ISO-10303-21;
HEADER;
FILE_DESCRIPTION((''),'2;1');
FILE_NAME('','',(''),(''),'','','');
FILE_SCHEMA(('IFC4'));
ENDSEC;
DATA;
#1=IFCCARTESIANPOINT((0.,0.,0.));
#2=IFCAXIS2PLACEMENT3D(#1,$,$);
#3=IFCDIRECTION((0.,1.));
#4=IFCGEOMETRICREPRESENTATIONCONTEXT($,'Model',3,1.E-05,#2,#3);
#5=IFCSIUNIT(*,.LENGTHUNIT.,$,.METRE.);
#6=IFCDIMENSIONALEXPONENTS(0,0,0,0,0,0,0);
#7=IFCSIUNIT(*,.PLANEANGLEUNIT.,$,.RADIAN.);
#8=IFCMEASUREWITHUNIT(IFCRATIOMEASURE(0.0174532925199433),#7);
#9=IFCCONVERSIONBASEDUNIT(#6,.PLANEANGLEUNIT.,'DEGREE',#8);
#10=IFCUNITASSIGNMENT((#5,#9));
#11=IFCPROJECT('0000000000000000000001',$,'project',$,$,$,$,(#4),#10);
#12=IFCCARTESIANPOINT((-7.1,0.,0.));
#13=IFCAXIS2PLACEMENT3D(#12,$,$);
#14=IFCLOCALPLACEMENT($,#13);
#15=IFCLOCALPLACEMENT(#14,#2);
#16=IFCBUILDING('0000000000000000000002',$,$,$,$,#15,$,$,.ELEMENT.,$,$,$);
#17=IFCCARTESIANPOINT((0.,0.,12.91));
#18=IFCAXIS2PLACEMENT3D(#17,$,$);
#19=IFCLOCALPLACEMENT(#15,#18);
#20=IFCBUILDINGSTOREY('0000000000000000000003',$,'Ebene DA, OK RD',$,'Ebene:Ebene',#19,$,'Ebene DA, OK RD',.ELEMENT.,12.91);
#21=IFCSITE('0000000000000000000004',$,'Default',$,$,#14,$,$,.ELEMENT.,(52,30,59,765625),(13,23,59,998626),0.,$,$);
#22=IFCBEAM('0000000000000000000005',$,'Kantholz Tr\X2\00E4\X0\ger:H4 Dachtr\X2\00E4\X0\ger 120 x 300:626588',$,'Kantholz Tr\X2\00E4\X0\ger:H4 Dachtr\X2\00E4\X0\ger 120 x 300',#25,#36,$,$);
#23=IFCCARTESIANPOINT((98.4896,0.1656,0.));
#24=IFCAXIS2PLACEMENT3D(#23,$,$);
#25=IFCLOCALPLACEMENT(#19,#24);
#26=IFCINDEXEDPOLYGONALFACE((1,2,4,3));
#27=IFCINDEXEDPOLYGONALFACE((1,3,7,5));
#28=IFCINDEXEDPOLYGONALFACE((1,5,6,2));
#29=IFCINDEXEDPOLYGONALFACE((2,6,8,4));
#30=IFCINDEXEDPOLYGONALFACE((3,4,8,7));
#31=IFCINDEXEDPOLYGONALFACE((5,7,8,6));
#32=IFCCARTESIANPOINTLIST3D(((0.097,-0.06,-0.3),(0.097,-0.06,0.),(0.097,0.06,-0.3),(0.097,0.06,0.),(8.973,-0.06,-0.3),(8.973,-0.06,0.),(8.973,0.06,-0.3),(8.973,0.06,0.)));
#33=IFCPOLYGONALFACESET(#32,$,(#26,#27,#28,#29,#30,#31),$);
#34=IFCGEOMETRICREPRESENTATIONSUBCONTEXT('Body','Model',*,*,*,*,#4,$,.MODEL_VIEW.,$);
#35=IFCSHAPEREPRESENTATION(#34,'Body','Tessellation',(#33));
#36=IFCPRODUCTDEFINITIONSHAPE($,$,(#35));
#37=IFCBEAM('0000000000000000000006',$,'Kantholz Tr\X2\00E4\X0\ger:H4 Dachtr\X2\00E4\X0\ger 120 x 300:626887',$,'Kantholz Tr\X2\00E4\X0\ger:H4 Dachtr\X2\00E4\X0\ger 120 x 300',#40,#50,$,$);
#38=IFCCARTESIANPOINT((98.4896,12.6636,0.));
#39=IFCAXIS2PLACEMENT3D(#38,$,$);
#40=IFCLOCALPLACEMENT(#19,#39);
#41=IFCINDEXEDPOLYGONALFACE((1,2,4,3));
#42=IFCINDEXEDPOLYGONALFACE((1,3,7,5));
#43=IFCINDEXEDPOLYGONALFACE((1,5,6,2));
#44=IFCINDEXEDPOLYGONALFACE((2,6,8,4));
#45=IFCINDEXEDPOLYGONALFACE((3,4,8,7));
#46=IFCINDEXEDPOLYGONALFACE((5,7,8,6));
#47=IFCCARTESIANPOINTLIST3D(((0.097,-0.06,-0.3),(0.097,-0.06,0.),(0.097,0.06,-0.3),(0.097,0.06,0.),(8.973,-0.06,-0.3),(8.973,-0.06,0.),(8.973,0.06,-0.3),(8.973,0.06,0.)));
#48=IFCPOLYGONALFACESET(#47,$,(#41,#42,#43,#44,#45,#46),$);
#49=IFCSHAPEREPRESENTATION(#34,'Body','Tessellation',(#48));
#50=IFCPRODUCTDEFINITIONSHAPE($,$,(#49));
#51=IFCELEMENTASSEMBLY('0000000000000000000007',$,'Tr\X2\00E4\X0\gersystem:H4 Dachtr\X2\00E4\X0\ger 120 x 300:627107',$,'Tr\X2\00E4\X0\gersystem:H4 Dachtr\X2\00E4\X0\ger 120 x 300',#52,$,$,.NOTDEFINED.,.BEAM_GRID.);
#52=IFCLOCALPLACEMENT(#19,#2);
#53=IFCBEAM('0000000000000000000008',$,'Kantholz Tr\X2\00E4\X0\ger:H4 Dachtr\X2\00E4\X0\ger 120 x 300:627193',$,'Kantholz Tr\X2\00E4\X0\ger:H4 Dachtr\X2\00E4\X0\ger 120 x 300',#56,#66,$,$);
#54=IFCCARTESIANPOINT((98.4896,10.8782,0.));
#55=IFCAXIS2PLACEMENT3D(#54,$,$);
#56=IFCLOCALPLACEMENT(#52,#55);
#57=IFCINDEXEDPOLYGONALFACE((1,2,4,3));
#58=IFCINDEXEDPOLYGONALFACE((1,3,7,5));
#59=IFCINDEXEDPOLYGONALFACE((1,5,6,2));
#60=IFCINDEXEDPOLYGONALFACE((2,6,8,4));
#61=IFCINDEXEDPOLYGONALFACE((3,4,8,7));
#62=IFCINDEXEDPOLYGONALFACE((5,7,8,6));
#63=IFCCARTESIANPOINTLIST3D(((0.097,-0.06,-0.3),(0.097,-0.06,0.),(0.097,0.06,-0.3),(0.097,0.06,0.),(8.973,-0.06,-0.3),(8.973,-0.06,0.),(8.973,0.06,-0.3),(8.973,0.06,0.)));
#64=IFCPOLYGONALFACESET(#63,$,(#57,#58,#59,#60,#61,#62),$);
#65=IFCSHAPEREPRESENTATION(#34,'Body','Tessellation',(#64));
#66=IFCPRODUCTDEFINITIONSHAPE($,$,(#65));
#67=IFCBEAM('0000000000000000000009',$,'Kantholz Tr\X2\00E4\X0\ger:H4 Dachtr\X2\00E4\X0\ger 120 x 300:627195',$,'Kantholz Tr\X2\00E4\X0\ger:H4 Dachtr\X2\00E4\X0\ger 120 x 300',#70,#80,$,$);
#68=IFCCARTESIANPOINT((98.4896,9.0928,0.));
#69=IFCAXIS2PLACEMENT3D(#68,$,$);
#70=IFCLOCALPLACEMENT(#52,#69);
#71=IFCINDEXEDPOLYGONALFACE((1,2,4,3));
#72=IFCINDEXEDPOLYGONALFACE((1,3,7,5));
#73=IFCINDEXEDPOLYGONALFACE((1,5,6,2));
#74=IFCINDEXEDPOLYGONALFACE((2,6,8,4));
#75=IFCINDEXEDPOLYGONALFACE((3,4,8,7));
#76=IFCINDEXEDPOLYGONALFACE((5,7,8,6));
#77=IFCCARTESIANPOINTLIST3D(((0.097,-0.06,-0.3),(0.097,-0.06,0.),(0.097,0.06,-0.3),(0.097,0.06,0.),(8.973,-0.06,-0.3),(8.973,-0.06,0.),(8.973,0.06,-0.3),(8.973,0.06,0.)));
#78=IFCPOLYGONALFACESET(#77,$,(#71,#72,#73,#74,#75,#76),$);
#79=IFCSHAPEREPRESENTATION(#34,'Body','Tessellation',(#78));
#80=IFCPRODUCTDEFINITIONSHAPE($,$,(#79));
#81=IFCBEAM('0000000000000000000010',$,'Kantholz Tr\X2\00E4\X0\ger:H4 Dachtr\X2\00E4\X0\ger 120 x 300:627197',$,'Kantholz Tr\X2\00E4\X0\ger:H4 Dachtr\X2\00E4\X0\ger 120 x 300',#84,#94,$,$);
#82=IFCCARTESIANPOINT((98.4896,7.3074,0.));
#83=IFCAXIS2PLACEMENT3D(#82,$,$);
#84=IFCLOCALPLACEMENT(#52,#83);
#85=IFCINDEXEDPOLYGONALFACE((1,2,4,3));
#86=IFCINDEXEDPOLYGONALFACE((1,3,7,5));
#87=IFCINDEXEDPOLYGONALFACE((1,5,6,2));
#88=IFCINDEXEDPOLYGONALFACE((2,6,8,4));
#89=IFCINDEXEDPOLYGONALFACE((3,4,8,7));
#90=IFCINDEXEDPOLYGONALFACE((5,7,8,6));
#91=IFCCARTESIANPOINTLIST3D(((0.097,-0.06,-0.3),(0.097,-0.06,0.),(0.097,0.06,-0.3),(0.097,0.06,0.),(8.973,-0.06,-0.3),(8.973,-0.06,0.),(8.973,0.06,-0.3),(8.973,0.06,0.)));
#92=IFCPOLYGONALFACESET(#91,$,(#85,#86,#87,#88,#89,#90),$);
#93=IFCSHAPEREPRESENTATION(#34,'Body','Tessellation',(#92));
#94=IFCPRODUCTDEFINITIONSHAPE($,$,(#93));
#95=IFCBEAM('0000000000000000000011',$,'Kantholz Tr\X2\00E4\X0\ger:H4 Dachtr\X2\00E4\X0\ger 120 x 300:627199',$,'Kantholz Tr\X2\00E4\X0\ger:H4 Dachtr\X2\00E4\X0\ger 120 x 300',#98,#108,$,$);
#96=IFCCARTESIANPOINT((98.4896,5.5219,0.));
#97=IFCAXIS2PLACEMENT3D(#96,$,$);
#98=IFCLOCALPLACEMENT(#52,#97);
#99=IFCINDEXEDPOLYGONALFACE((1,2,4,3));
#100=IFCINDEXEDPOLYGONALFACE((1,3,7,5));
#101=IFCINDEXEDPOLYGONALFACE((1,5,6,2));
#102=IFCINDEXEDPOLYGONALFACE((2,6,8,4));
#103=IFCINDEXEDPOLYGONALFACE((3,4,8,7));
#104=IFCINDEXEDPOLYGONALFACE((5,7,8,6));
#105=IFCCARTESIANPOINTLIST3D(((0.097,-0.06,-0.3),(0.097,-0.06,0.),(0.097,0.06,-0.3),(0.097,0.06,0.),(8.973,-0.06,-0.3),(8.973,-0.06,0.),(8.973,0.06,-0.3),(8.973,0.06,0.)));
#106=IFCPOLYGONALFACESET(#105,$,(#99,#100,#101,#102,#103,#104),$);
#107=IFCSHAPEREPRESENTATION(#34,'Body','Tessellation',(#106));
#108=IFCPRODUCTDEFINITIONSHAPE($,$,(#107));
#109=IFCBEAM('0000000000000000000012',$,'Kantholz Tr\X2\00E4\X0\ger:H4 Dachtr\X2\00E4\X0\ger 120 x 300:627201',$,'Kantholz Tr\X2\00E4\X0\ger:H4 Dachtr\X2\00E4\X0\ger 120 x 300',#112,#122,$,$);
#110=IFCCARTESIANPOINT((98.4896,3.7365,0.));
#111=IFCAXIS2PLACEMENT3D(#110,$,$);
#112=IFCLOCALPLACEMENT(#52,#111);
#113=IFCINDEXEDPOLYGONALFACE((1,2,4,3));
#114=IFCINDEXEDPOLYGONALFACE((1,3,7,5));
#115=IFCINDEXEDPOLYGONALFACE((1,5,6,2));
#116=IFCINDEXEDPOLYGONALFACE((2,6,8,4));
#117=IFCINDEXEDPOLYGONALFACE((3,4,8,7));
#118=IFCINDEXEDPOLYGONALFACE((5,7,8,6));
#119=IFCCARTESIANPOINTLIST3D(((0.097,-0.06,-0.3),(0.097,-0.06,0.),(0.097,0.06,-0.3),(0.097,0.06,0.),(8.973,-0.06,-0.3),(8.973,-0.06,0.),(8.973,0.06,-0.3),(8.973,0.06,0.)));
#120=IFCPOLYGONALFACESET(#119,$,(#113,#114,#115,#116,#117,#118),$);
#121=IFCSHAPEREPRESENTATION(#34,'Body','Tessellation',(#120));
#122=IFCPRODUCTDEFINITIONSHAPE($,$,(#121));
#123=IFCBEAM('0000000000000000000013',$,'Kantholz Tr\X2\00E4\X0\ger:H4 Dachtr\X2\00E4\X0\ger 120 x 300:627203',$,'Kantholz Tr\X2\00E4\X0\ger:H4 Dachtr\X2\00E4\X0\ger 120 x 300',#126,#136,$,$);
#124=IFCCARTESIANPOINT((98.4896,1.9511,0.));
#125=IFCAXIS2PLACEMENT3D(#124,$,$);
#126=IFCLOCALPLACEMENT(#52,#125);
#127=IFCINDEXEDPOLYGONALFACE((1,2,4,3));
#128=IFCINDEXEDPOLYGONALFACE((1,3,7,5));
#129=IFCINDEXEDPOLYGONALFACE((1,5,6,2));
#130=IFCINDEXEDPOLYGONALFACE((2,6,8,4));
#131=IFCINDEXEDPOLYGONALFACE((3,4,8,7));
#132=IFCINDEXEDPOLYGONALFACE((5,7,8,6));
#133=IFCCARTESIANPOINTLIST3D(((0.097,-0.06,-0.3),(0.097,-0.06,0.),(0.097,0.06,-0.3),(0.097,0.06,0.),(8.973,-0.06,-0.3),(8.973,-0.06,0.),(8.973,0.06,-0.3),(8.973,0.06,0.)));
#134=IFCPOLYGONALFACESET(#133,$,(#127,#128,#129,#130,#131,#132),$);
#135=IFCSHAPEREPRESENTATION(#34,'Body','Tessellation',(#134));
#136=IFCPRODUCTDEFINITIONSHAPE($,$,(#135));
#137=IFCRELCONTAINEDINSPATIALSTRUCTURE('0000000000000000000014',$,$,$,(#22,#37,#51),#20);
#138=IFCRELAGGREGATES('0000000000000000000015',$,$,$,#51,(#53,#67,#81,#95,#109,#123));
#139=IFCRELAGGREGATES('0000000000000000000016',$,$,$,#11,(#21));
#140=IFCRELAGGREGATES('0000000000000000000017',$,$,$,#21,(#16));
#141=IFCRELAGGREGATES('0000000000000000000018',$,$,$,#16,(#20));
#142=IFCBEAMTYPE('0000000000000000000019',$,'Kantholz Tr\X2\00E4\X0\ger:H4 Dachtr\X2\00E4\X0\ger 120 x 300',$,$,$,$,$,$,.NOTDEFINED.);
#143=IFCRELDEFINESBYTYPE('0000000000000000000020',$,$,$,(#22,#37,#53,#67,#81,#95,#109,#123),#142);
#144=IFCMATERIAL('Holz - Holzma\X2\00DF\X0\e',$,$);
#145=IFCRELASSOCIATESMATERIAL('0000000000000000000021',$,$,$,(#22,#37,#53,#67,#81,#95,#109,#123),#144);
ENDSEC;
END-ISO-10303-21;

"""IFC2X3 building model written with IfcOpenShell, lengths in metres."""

from ifc_helpers import new_model, entity, si_unit, converted_unit, direction, frame, frame_2d, origin, place, context, subcontext, project, spatial, rectangle, extrude, material, type_object, element, aggregate, save


model = new_model("IFC2X3")

# Units and contexts
model_context = context("Model", 3, precision=1e-05, world=origin(), true_north=direction((0.0, 1.0)))
body_context = subcontext(model_context, "Body", "Model", "MODEL_VIEW")
ifc_project = project(units=[si_unit("LENGTHUNIT", "METRE"), converted_unit("PLANEANGLEUNIT", "DEGREE", entity("IfcRatioMeasure", 0.0174532925199433), si_unit("PLANEANGLEUNIT", "RADIAN"), dimensions=[0, 0, 0, 0, 0, 0, 0])], contexts=[model_context])

# Site, building, storey
site_placement = place(None, frame((-7.1, 0.0, 0.0)))
site = spatial("IfcSite", under=ifc_project, at=site_placement, Name="Default", CompositionType="ELEMENT", RefLatitude=(52, 30, 59, 765625), RefLongitude=(13, 23, 59, 998626), RefElevation=0.0)
building_placement = place(site_placement, origin())
building = spatial("IfcBuilding", under=site, at=building_placement, CompositionType="ELEMENT")
storey_placement = place(building_placement, frame((0.0, 0.0, 12.91)))
storey = spatial("IfcBuildingStorey", under=building, at=storey_placement, Name="Ebene DA, OK RD", ObjectType="Ebene:Ebene", LongName="Ebene DA, OK RD", CompositionType="ELEMENT", Elevation=12.91)

# Beams
ifc_material_1 = material(Name="Holz - Holzmaße")
beam_type = type_object("IfcBeamType", Name="Kantholz Träger:H4 Dachträger 120 x 300", PredefinedType="NOTDEFINED")
beam_1_placement = place(storey_placement, frame((98.4896, 0.1656, 0.0)))
element("IfcBeam", 1, at=beam_1_placement, inside=storey, type_object=beam_type, material=ifc_material_1, Name="Kantholz Träger:H4 Dachträger 120 x 300:626588", ObjectType="Kantholz Träger:H4 Dachträger 120 x 300", context=body_context, shape_type="SweptSolid", body=[
    extrude(rectangle(XDim=0.3, YDim=0.12, at=frame_2d((0.0, 0.0), x_axis=(1.0, 0.0))), frame((0.097, 0.0, -0.15), z_axis=(1.0, 0.0, 0.0), x_axis=(0.0, 0.0, -1.0)), (0.0, 0.0, 1.0), 8.876),
])
beam_2_placement = place(storey_placement, frame((98.4896, 12.6636, 0.0)))
element("IfcBeam", 2, at=beam_2_placement, inside=storey, type_object=beam_type, material=ifc_material_1, Name="Kantholz Träger:H4 Dachträger 120 x 300:626887", ObjectType="Kantholz Träger:H4 Dachträger 120 x 300", context=body_context, shape_type="SweptSolid", body=[
    extrude(rectangle(XDim=0.3, YDim=0.12, at=frame_2d((0.0, 0.0), x_axis=(1.0, 0.0))), frame((0.097, 0.0, -0.15), z_axis=(1.0, 0.0, 0.0), x_axis=(0.0, 0.0, -1.0)), (0.0, 0.0, 1.0), 8.876),
])

# Element assembly, beams
assembly_placement = place(storey_placement, origin())
assembly = element("IfcElementAssembly", 3, at=assembly_placement, inside=storey, Name="Trägersystem:H4 Dachträger 120 x 300:627107", ObjectType="Trägersystem:H4 Dachträger 120 x 300", AssemblyPlace="NOTDEFINED", PredefinedType="BEAM_GRID")
beam_3_placement = place(assembly_placement, frame((98.4896, 10.8782, 0.0)))
beam_3 = element("IfcBeam", 4, at=beam_3_placement, type_object=beam_type, material=ifc_material_1, Name="Kantholz Träger:H4 Dachträger 120 x 300:627193", ObjectType="Kantholz Träger:H4 Dachträger 120 x 300", context=body_context, shape_type="SweptSolid", body=[
    extrude(rectangle(XDim=0.3, YDim=0.12, at=frame_2d((0.0, 0.0), x_axis=(1.0, 0.0))), frame((0.097, 0.0, -0.15), z_axis=(1.0, 0.0, 0.0), x_axis=(0.0, 0.0, -1.0)), (0.0, 0.0, 1.0), 8.876),
])
beam_4_placement = place(assembly_placement, frame((98.4896, 9.0928, 0.0)))
beam_4 = element("IfcBeam", 5, at=beam_4_placement, type_object=beam_type, material=ifc_material_1, Name="Kantholz Träger:H4 Dachträger 120 x 300:627195", ObjectType="Kantholz Träger:H4 Dachträger 120 x 300", context=body_context, shape_type="SweptSolid", body=[
    extrude(rectangle(XDim=0.3, YDim=0.12, at=frame_2d((0.0, 0.0), x_axis=(1.0, 0.0))), frame((0.097, 0.0, -0.15), z_axis=(1.0, 0.0, 0.0), x_axis=(0.0, 0.0, -1.0)), (0.0, 0.0, 1.0), 8.876),
])
beam_5_placement = place(assembly_placement, frame((98.4896, 7.3074, 0.0)))
beam_5 = element("IfcBeam", 6, at=beam_5_placement, type_object=beam_type, material=ifc_material_1, Name="Kantholz Träger:H4 Dachträger 120 x 300:627197", ObjectType="Kantholz Träger:H4 Dachträger 120 x 300", context=body_context, shape_type="SweptSolid", body=[
    extrude(rectangle(XDim=0.3, YDim=0.12, at=frame_2d((0.0, 0.0), x_axis=(1.0, 0.0))), frame((0.097, 0.0, -0.15), z_axis=(1.0, 0.0, 0.0), x_axis=(0.0, 0.0, -1.0)), (0.0, 0.0, 1.0), 8.876),
])
beam_6_placement = place(assembly_placement, frame((98.4896, 5.5219, 0.0)))
beam_6 = element("IfcBeam", 7, at=beam_6_placement, type_object=beam_type, material=ifc_material_1, Name="Kantholz Träger:H4 Dachträger 120 x 300:627199", ObjectType="Kantholz Träger:H4 Dachträger 120 x 300", context=body_context, shape_type="SweptSolid", body=[
    extrude(rectangle(XDim=0.3, YDim=0.12, at=frame_2d((0.0, 0.0), x_axis=(1.0, 0.0))), frame((0.097, 0.0, -0.15), z_axis=(1.0, 0.0, 0.0), x_axis=(0.0, 0.0, -1.0)), (0.0, 0.0, 1.0), 8.876),
])
beam_7_placement = place(assembly_placement, frame((98.4896, 3.7365, 0.0)))
beam_7 = element("IfcBeam", 8, at=beam_7_placement, type_object=beam_type, material=ifc_material_1, Name="Kantholz Träger:H4 Dachträger 120 x 300:627201", ObjectType="Kantholz Träger:H4 Dachträger 120 x 300", context=body_context, shape_type="SweptSolid", body=[
    extrude(rectangle(XDim=0.3, YDim=0.12, at=frame_2d((0.0, 0.0), x_axis=(1.0, 0.0))), frame((0.097, 0.0, -0.15), z_axis=(1.0, 0.0, 0.0), x_axis=(0.0, 0.0, -1.0)), (0.0, 0.0, 1.0), 8.876),
])
beam_8_placement = place(assembly_placement, frame((98.4896, 1.9511, 0.0)))
beam_8 = element("IfcBeam", 9, at=beam_8_placement, type_object=beam_type, material=ifc_material_1, Name="Kantholz Träger:H4 Dachträger 120 x 300:627203", ObjectType="Kantholz Träger:H4 Dachträger 120 x 300", context=body_context, shape_type="SweptSolid", body=[
    extrude(rectangle(XDim=0.3, YDim=0.12, at=frame_2d((0.0, 0.0), x_axis=(1.0, 0.0))), frame((0.097, 0.0, -0.15), z_axis=(1.0, 0.0, 0.0), x_axis=(0.0, 0.0, -1.0)), (0.0, 0.0, 1.0), 8.876),
])
aggregate(assembly, [beam_3, beam_4, beam_5, beam_6, beam_7, beam_8])

save(model, "model.ifc")
